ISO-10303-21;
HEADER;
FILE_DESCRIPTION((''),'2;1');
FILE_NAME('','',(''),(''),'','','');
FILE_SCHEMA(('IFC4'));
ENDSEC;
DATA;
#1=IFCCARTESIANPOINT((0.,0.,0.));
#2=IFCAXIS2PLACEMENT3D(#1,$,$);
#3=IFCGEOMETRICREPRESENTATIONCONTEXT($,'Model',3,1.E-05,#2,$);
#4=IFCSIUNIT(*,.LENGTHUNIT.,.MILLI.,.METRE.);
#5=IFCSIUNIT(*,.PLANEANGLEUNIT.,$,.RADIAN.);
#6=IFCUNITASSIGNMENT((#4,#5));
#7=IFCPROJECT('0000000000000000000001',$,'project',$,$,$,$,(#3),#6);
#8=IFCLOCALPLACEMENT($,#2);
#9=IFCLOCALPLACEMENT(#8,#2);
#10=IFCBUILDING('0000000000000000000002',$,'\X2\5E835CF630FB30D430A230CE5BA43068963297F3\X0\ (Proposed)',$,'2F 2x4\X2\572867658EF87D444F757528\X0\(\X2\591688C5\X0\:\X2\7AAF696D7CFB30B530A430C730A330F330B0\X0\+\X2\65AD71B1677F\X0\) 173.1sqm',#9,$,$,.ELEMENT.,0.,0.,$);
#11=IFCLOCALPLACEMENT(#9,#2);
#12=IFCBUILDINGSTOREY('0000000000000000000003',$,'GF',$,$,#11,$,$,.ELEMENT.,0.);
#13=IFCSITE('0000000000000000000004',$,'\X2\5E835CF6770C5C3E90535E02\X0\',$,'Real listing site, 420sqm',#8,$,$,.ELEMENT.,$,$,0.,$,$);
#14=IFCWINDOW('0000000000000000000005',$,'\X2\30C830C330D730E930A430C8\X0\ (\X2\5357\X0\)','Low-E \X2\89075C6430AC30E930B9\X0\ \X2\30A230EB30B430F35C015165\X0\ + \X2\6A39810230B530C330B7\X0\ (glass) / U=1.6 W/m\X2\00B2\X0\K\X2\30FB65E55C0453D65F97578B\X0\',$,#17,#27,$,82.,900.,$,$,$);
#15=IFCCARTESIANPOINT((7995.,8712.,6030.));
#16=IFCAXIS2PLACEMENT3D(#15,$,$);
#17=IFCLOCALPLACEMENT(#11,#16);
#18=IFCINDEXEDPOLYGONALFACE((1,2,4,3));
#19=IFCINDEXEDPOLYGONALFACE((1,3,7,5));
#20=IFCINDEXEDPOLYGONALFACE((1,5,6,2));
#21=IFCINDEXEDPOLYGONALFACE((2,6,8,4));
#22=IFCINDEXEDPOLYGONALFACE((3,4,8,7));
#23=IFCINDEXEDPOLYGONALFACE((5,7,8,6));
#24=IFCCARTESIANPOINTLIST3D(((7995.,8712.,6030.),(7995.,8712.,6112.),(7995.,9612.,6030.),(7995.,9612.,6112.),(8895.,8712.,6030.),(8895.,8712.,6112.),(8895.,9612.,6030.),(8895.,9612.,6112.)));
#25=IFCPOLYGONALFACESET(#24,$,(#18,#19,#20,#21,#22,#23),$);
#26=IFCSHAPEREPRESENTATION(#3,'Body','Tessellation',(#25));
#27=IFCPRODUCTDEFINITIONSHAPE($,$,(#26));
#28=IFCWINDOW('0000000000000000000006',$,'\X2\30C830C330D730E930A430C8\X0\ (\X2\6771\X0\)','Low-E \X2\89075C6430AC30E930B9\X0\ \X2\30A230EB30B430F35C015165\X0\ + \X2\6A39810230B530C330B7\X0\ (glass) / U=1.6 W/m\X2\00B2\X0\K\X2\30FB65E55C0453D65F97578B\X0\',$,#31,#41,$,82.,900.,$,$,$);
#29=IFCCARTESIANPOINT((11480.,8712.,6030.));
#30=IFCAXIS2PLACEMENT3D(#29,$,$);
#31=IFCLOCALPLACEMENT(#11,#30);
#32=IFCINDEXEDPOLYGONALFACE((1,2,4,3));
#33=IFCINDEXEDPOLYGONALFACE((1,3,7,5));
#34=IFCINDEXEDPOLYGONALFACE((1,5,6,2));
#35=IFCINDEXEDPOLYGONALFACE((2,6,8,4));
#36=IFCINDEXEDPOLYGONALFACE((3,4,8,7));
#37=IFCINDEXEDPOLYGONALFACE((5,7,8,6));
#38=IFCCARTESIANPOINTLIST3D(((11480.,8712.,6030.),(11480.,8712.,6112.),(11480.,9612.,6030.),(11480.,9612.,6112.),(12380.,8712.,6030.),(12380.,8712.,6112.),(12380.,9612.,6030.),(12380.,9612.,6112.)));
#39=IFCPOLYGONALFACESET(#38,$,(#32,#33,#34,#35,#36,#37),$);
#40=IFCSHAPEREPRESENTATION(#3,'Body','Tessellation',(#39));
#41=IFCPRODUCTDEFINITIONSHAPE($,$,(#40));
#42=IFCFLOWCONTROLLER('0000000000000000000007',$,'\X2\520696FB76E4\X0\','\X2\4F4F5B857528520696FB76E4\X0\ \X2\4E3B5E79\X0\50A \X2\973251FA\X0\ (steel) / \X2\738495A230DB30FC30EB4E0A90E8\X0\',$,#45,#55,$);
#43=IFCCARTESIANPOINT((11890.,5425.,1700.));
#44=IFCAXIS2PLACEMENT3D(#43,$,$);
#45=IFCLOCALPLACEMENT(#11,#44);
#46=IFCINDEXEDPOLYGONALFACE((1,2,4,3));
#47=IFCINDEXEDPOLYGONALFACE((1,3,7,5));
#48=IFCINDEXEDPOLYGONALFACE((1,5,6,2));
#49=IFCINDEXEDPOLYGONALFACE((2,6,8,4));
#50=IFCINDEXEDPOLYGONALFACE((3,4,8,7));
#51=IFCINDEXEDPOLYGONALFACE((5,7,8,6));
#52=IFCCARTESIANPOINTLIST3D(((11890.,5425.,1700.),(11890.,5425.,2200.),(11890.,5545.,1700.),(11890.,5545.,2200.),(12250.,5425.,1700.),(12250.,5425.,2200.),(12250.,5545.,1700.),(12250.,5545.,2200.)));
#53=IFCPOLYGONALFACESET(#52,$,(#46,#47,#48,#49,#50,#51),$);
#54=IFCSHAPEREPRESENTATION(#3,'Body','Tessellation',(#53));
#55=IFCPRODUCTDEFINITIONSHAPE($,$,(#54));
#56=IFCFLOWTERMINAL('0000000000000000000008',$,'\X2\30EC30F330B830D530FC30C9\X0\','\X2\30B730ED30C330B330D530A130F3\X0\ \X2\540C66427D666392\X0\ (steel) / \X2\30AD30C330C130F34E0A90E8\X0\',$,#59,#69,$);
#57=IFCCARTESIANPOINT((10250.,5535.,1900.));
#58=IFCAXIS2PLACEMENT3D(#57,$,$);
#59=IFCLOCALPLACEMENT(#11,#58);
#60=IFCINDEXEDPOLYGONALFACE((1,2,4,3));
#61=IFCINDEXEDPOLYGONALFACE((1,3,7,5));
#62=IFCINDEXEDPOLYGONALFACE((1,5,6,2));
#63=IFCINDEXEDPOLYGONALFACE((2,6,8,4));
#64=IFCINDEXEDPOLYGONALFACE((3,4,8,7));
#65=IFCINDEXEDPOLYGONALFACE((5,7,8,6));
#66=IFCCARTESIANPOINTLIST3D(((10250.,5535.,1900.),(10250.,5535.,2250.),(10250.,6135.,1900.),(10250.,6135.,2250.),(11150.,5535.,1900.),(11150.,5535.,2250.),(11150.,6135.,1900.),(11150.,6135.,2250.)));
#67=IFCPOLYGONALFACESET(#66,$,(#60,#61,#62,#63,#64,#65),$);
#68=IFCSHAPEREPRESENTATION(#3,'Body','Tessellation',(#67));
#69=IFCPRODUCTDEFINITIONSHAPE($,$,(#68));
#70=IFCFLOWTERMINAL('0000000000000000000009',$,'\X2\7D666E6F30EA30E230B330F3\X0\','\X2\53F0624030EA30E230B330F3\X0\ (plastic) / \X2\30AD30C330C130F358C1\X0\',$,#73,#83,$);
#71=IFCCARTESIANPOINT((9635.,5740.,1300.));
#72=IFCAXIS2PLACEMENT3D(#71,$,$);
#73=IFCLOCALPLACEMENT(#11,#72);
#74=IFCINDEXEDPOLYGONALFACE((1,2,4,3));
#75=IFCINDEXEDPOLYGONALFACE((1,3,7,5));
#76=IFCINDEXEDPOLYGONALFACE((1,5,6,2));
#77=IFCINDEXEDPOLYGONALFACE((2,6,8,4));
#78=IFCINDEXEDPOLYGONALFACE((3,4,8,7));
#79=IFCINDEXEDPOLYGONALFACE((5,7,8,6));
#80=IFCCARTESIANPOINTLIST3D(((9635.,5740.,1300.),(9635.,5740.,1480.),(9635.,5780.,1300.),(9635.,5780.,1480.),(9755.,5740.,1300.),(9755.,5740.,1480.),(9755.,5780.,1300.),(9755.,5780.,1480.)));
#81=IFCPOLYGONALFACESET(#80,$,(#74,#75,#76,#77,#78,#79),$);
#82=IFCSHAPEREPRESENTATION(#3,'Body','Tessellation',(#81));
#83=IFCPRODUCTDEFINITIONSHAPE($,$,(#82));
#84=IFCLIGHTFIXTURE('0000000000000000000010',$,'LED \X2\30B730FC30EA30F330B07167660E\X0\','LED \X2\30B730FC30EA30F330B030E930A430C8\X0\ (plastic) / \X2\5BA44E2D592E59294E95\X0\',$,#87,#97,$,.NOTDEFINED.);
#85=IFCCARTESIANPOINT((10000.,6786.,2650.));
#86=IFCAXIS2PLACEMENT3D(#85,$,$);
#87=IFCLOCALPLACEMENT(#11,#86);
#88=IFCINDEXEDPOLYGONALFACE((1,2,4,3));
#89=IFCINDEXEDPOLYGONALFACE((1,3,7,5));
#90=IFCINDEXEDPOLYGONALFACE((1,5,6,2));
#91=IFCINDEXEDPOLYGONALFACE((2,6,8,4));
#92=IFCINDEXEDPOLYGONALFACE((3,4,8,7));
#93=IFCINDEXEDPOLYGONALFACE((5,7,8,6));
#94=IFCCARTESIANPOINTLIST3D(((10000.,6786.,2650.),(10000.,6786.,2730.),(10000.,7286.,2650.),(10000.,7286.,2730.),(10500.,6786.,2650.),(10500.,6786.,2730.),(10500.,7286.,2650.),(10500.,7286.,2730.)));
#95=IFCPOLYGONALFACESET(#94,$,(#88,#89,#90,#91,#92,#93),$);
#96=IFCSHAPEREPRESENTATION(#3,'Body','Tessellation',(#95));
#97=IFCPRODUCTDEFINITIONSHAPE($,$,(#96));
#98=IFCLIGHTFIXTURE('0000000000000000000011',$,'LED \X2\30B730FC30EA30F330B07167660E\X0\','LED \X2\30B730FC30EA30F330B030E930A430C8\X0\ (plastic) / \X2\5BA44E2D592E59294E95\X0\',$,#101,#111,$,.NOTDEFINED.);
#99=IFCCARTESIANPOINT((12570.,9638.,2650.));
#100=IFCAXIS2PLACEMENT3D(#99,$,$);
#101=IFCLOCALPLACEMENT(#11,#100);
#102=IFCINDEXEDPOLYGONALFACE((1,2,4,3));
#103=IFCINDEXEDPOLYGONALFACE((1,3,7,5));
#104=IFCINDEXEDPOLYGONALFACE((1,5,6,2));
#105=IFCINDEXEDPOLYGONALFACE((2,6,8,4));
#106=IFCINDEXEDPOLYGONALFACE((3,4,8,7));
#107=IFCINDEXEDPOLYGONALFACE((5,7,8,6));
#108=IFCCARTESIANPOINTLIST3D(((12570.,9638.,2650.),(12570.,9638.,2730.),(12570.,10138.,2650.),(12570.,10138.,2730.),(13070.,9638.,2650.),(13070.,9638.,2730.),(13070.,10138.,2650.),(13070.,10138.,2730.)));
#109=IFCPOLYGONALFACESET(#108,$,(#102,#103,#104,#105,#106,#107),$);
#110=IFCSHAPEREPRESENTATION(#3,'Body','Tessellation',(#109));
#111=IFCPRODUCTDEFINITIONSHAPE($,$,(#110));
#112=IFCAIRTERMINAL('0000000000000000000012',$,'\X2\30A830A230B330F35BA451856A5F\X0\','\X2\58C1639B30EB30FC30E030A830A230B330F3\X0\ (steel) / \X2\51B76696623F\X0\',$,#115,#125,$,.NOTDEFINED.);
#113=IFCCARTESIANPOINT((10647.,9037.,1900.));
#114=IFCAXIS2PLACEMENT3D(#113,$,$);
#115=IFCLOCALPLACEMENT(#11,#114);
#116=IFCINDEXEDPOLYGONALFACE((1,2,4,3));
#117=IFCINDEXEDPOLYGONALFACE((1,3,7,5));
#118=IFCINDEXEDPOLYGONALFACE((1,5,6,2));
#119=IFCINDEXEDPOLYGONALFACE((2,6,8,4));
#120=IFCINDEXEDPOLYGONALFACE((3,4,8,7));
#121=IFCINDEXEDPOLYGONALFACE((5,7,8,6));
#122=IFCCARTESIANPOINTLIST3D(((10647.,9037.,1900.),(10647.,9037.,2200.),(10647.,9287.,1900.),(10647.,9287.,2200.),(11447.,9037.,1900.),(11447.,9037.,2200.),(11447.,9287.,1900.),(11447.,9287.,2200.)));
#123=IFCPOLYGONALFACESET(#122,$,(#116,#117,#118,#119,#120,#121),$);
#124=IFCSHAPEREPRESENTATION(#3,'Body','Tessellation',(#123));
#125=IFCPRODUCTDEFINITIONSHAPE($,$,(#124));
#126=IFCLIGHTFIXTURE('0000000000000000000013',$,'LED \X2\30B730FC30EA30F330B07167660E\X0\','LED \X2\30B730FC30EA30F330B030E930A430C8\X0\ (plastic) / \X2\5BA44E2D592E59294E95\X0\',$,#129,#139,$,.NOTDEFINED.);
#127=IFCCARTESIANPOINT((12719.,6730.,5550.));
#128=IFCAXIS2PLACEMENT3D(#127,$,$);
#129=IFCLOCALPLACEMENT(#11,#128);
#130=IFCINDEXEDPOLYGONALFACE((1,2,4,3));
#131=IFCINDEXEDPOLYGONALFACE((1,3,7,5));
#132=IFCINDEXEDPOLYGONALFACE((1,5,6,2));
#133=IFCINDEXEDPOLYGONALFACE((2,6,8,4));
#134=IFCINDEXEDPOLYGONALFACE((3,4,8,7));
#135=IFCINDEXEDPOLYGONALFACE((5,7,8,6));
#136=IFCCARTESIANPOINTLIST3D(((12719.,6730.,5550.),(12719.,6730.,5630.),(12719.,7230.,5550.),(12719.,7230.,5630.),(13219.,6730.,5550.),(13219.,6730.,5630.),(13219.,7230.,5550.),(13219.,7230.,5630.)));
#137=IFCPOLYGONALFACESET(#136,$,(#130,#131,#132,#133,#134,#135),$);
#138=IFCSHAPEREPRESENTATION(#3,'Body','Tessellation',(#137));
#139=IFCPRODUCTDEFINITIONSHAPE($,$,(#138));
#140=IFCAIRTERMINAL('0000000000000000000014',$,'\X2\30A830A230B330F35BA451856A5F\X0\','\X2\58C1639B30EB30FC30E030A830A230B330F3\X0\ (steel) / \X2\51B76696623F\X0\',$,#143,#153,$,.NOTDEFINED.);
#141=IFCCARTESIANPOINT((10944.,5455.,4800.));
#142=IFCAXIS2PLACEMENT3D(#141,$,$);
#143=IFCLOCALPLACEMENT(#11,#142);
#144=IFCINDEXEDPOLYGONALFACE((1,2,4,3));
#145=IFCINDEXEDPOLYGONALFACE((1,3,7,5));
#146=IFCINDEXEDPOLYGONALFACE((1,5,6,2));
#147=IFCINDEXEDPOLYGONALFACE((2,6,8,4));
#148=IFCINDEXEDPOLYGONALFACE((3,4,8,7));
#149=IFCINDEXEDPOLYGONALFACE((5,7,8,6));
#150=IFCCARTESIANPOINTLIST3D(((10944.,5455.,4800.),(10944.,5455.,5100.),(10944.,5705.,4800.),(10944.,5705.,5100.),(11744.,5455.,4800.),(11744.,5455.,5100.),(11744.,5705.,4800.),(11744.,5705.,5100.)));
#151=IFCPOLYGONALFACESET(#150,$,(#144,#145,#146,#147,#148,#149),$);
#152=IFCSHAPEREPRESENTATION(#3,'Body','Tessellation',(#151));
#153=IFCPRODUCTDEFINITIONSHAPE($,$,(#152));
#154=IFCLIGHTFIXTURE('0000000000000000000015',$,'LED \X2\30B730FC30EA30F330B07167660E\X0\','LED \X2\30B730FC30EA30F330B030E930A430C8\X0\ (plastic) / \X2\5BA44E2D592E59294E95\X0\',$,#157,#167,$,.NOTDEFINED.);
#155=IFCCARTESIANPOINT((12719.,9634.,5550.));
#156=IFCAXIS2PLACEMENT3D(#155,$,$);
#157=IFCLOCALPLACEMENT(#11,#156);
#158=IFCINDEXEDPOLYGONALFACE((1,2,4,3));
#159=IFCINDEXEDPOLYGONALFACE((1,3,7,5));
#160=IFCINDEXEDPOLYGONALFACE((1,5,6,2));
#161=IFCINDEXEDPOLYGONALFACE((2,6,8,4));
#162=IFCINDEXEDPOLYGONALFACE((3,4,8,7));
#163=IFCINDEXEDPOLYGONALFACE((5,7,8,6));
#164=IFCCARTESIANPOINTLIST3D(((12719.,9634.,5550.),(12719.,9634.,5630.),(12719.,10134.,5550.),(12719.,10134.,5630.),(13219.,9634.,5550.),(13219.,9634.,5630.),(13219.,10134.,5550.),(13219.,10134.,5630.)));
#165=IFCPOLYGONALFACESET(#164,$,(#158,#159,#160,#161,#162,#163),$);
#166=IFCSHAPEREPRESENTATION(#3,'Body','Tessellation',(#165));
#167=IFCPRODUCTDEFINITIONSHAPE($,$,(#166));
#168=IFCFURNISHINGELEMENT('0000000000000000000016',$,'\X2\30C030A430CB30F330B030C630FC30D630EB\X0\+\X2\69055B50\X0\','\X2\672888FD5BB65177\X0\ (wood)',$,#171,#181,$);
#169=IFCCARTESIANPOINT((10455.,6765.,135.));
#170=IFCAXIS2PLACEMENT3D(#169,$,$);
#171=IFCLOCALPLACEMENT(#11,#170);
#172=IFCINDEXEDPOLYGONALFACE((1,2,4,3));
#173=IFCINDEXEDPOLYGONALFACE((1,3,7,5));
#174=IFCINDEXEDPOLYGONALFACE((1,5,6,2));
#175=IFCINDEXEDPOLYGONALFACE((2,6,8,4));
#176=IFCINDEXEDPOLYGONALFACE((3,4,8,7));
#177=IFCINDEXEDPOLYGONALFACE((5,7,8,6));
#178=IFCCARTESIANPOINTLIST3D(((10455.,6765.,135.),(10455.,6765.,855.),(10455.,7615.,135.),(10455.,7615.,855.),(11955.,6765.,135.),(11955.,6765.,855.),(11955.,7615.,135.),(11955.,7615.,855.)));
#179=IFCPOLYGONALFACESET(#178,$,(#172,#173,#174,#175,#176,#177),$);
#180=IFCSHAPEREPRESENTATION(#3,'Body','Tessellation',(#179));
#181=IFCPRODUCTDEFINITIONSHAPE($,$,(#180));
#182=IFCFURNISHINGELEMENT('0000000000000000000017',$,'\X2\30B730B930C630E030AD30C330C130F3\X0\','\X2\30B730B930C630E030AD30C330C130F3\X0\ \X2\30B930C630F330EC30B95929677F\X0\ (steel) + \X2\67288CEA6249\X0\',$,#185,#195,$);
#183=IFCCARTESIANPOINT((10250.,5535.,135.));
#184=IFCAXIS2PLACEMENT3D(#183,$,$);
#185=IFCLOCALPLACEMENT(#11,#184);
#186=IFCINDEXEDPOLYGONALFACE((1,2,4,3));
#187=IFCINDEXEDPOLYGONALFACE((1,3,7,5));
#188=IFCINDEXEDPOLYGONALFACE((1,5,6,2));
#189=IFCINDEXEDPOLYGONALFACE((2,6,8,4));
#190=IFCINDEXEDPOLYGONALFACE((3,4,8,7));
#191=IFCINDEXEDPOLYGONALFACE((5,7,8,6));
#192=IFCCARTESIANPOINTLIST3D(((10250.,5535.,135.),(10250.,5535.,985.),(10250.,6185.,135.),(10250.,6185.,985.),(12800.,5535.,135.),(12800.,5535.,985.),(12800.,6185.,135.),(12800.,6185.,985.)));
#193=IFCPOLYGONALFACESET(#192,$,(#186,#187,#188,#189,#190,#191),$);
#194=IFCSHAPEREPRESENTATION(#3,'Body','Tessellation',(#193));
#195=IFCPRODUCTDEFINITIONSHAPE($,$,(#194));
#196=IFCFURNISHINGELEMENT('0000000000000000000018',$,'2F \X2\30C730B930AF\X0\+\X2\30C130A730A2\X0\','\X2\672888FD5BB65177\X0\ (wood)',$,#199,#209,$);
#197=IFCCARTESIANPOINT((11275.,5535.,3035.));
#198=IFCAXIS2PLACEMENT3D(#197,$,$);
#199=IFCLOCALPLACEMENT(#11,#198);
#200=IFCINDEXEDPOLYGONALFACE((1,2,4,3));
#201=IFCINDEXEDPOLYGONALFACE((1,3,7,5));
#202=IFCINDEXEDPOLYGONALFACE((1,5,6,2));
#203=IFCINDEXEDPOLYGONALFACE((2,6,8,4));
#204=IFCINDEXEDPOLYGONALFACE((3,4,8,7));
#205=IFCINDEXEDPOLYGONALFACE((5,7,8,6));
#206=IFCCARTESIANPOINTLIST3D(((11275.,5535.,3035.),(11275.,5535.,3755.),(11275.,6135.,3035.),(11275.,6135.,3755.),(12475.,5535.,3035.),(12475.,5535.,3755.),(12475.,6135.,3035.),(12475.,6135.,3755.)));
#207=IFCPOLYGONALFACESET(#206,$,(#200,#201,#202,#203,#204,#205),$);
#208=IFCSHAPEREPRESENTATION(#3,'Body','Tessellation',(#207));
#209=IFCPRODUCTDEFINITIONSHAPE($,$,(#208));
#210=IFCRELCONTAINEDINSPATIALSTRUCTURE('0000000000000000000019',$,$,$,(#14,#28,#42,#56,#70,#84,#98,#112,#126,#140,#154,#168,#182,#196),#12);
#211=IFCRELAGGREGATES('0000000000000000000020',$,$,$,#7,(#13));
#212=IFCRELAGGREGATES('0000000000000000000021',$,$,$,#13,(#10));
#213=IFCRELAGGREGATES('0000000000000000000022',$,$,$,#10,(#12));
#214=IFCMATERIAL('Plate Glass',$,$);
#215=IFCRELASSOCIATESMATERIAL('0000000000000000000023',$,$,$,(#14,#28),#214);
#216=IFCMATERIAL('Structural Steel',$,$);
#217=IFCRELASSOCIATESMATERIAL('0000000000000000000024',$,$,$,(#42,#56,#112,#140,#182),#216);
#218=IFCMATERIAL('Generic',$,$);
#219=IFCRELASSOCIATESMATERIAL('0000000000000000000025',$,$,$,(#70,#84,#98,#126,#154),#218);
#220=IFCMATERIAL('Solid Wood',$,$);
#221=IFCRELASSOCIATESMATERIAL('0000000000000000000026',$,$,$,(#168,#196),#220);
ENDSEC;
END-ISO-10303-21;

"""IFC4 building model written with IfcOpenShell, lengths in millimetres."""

from ifc_helpers import new_model, si_unit, frame, frame_2d, origin, place, context, project, spatial, rectangle, extrude, material, element, save


model = new_model("IFC4")

# Units and contexts
model_context = context("Model", 3, precision=1e-05, world=origin())
ifc_project = project(units=[si_unit("LENGTHUNIT", "METRE", prefix="MILLI"), si_unit("PLANEANGLEUNIT", "RADIAN")], contexts=[model_context])

# Site, building, storey
site_placement = place(None, origin())
site = spatial("IfcSite", under=ifc_project, at=site_placement, Name="広島県尾道市", ObjectType="Real listing site, 420sqm", CompositionType="ELEMENT", RefElevation=0.0)
building_placement = place(site_placement, origin())
building = spatial("IfcBuilding", under=site, at=building_placement, Name="広島・ピアノ室と防音 (Proposed)", ObjectType="2F 2x4在来軸組併用(外装:窯業系サイディング+断熱板) 173.1sqm", CompositionType="ELEMENT", ElevationOfRefHeight=0.0, ElevationOfTerrain=0.0)
storey_placement = place(building_placement, origin())
storey = spatial("IfcBuildingStorey", under=building, at=storey_placement, Name="GF", CompositionType="ELEMENT", Elevation=0.0)

# Shared definitions
ifc_material_1 = material(Name="Solid Wood")

# Windows
ifc_material_2 = material(Name="Plate Glass")
window_1_placement = place(storey_placement, frame((7995.0, 8712.0, 6030.0)))
element("IfcWindow", 1, at=window_1_placement, inside=storey, material=ifc_material_2, Name="トップライト (南)", Description="Low-E 複層ガラス アルゴン封入 + 樹脂サッシ (glass) / U=1.6 W/m²K・日射取得型", OverallHeight=82.0, OverallWidth=900.0, context=model_context, shape_type="SweptSolid", body=[
    extrude(rectangle(XDim=900.0, YDim=900.0, at=frame_2d((450.0, 450.0))), frame((7995.0, 8712.0, 6030.0)), (0.0, 0.0, 1.0), 82.0),
])
window_2_placement = place(storey_placement, frame((11480.0, 8712.0, 6030.0)))
element("IfcWindow", 2, at=window_2_placement, inside=storey, material=ifc_material_2, Name="トップライト (東)", Description="Low-E 複層ガラス アルゴン封入 + 樹脂サッシ (glass) / U=1.6 W/m²K・日射取得型", OverallHeight=82.0, OverallWidth=900.0, context=model_context, shape_type="SweptSolid", body=[
    extrude(rectangle(XDim=900.0, YDim=900.0, at=frame_2d((450.0, 450.0))), frame((11480.0, 8712.0, 6030.0)), (0.0, 0.0, 1.0), 82.0),
])

# Flow controller
ifc_material_3 = material(Name="Structural Steel")
flow_controller_placement = place(storey_placement, frame((11890.0, 5425.0, 1700.0)))
element("IfcFlowController", 3, at=flow_controller_placement, inside=storey, material=ifc_material_3, Name="分電盤", Description="住宅用分電盤 主幹50A 露出 (steel) / 玄関ホール上部", context=model_context, shape_type="SweptSolid", body=[
    extrude(rectangle(XDim=360.0, YDim=120.0, at=frame_2d((180.0, 60.0))), frame((11890.0, 5425.0, 1700.0)), (0.0, 0.0, 1.0), 500.0),
])

# Flow terminals
flow_terminal_1_placement = place(storey_placement, frame((10250.0, 5535.0, 1900.0)))
element("IfcFlowTerminal", 4, at=flow_terminal_1_placement, inside=storey, material=ifc_material_3, Name="レンジフード", Description="シロッコファン 同時給排 (steel) / キッチン上部", context=model_context, shape_type="SweptSolid", body=[
    extrude(rectangle(XDim=900.0, YDim=600.0, at=frame_2d((450.0, 300.0))), frame((10250.0, 5535.0, 1900.0)), (0.0, 0.0, 1.0), 350.0),
])
ifc_material_4 = material(Name="Generic")
flow_terminal_2_placement = place(storey_placement, frame((9635.0, 5740.0, 1300.0)))
element("IfcFlowTerminal", 5, at=flow_terminal_2_placement, inside=storey, material=ifc_material_4, Name="給湯リモコン", Description="台所リモコン (plastic) / キッチン壁", context=model_context, shape_type="SweptSolid", body=[
    extrude(rectangle(XDim=120.0, YDim=40.0, at=frame_2d((60.0, 20.0))), frame((9635.0, 5740.0, 1300.0)), (0.0, 0.0, 1.0), 180.0),
])

# Light fixtures
light_fixture_1_placement = place(storey_placement, frame((10000.0, 6786.0, 2650.0)))
element("IfcLightFixture", 6, at=light_fixture_1_placement, inside=storey, material=ifc_material_4, Name="LED シーリング照明", Description="LED シーリングライト (plastic) / 室中央天井", PredefinedType="NOTDEFINED", context=model_context, shape_type="SweptSolid", body=[
    extrude(rectangle(XDim=500.0, YDim=500.0, at=frame_2d((250.0, 250.0))), frame((10000.0, 6786.0, 2650.0)), (0.0, 0.0, 1.0), 80.0),
])
light_fixture_2_placement = place(storey_placement, frame((12570.0, 9638.0, 2650.0)))
element("IfcLightFixture", 7, at=light_fixture_2_placement, inside=storey, material=ifc_material_4, Name="LED シーリング照明", Description="LED シーリングライト (plastic) / 室中央天井", PredefinedType="NOTDEFINED", context=model_context, shape_type="SweptSolid", body=[
    extrude(rectangle(XDim=500.0, YDim=500.0, at=frame_2d((250.0, 250.0))), frame((12570.0, 9638.0, 2650.0)), (0.0, 0.0, 1.0), 80.0),
])

# Air terminal
air_terminal_1_placement = place(storey_placement, frame((10647.0, 9037.0, 1900.0)))
element("IfcAirTerminal", 8, at=air_terminal_1_placement, inside=storey, material=ifc_material_3, Name="エアコン室内機", Description="壁掛ルームエアコン (steel) / 冷暖房", PredefinedType="NOTDEFINED", context=model_context, shape_type="SweptSolid", body=[
    extrude(rectangle(XDim=800.0, YDim=250.0, at=frame_2d((400.0, 125.0))), frame((10647.0, 9037.0, 1900.0)), (0.0, 0.0, 1.0), 300.0),
])

# Light fixture
light_fixture_3_placement = place(storey_placement, frame((12719.0, 6730.0, 5550.0)))
element("IfcLightFixture", 9, at=light_fixture_3_placement, inside=storey, material=ifc_material_4, Name="LED シーリング照明", Description="LED シーリングライト (plastic) / 室中央天井", PredefinedType="NOTDEFINED", context=model_context, shape_type="SweptSolid", body=[
    extrude(rectangle(XDim=500.0, YDim=500.0, at=frame_2d((250.0, 250.0))), frame((12719.0, 6730.0, 5550.0)), (0.0, 0.0, 1.0), 80.0),
])

# Air terminal
air_terminal_2_placement = place(storey_placement, frame((10944.0, 5455.0, 4800.0)))
element("IfcAirTerminal", 10, at=air_terminal_2_placement, inside=storey, material=ifc_material_3, Name="エアコン室内機", Description="壁掛ルームエアコン (steel) / 冷暖房", PredefinedType="NOTDEFINED", context=model_context, shape_type="SweptSolid", body=[
    extrude(rectangle(XDim=800.0, YDim=250.0, at=frame_2d((400.0, 125.0))), frame((10944.0, 5455.0, 4800.0)), (0.0, 0.0, 1.0), 300.0),
])

# Light fixture
light_fixture_4_placement = place(storey_placement, frame((12719.0, 9634.0, 5550.0)))
element("IfcLightFixture", 11, at=light_fixture_4_placement, inside=storey, material=ifc_material_4, Name="LED シーリング照明", Description="LED シーリングライト (plastic) / 室中央天井", PredefinedType="NOTDEFINED", context=model_context, shape_type="SweptSolid", body=[
    extrude(rectangle(XDim=500.0, YDim=500.0, at=frame_2d((250.0, 250.0))), frame((12719.0, 9634.0, 5550.0)), (0.0, 0.0, 1.0), 80.0),
])

# Furnishing elements
furnishing_1_placement = place(storey_placement, frame((10455.0, 6765.0, 135.0)))
element("IfcFurnishingElement", 12, at=furnishing_1_placement, inside=storey, material=ifc_material_1, Name="ダイニングテーブル+椅子", Description="木製家具 (wood)", context=model_context, shape_type="SweptSolid", body=[
    extrude(rectangle(XDim=1500.0, YDim=850.0, at=frame_2d((750.0, 425.0))), frame((10455.0, 6765.0, 135.0)), (0.0, 0.0, 1.0), 720.0),
])
furnishing_2_placement = place(storey_placement, frame((10250.0, 5535.0, 135.0)))
element("IfcFurnishingElement", 13, at=furnishing_2_placement, inside=storey, material=ifc_material_3, Name="システムキッチン", Description="システムキッチン ステンレス天板 (steel) + 木質扉", context=model_context, shape_type="SweptSolid", body=[
    extrude(rectangle(XDim=2550.0, YDim=650.0, at=frame_2d((1275.0, 325.0))), frame((10250.0, 5535.0, 135.0)), (0.0, 0.0, 1.0), 850.0),
])
furnishing_3_placement = place(storey_placement, frame((11275.0, 5535.0, 3035.0)))
element("IfcFurnishingElement", 14, at=furnishing_3_placement, inside=storey, material=ifc_material_1, Name="2F デスク+チェア", Description="木製家具 (wood)", context=model_context, shape_type="SweptSolid", body=[
    extrude(rectangle(XDim=1200.0, YDim=600.0, at=frame_2d((600.0, 300.0))), frame((11275.0, 5535.0, 3035.0)), (0.0, 0.0, 1.0), 720.0),
])

save(model, "model.ifc")
